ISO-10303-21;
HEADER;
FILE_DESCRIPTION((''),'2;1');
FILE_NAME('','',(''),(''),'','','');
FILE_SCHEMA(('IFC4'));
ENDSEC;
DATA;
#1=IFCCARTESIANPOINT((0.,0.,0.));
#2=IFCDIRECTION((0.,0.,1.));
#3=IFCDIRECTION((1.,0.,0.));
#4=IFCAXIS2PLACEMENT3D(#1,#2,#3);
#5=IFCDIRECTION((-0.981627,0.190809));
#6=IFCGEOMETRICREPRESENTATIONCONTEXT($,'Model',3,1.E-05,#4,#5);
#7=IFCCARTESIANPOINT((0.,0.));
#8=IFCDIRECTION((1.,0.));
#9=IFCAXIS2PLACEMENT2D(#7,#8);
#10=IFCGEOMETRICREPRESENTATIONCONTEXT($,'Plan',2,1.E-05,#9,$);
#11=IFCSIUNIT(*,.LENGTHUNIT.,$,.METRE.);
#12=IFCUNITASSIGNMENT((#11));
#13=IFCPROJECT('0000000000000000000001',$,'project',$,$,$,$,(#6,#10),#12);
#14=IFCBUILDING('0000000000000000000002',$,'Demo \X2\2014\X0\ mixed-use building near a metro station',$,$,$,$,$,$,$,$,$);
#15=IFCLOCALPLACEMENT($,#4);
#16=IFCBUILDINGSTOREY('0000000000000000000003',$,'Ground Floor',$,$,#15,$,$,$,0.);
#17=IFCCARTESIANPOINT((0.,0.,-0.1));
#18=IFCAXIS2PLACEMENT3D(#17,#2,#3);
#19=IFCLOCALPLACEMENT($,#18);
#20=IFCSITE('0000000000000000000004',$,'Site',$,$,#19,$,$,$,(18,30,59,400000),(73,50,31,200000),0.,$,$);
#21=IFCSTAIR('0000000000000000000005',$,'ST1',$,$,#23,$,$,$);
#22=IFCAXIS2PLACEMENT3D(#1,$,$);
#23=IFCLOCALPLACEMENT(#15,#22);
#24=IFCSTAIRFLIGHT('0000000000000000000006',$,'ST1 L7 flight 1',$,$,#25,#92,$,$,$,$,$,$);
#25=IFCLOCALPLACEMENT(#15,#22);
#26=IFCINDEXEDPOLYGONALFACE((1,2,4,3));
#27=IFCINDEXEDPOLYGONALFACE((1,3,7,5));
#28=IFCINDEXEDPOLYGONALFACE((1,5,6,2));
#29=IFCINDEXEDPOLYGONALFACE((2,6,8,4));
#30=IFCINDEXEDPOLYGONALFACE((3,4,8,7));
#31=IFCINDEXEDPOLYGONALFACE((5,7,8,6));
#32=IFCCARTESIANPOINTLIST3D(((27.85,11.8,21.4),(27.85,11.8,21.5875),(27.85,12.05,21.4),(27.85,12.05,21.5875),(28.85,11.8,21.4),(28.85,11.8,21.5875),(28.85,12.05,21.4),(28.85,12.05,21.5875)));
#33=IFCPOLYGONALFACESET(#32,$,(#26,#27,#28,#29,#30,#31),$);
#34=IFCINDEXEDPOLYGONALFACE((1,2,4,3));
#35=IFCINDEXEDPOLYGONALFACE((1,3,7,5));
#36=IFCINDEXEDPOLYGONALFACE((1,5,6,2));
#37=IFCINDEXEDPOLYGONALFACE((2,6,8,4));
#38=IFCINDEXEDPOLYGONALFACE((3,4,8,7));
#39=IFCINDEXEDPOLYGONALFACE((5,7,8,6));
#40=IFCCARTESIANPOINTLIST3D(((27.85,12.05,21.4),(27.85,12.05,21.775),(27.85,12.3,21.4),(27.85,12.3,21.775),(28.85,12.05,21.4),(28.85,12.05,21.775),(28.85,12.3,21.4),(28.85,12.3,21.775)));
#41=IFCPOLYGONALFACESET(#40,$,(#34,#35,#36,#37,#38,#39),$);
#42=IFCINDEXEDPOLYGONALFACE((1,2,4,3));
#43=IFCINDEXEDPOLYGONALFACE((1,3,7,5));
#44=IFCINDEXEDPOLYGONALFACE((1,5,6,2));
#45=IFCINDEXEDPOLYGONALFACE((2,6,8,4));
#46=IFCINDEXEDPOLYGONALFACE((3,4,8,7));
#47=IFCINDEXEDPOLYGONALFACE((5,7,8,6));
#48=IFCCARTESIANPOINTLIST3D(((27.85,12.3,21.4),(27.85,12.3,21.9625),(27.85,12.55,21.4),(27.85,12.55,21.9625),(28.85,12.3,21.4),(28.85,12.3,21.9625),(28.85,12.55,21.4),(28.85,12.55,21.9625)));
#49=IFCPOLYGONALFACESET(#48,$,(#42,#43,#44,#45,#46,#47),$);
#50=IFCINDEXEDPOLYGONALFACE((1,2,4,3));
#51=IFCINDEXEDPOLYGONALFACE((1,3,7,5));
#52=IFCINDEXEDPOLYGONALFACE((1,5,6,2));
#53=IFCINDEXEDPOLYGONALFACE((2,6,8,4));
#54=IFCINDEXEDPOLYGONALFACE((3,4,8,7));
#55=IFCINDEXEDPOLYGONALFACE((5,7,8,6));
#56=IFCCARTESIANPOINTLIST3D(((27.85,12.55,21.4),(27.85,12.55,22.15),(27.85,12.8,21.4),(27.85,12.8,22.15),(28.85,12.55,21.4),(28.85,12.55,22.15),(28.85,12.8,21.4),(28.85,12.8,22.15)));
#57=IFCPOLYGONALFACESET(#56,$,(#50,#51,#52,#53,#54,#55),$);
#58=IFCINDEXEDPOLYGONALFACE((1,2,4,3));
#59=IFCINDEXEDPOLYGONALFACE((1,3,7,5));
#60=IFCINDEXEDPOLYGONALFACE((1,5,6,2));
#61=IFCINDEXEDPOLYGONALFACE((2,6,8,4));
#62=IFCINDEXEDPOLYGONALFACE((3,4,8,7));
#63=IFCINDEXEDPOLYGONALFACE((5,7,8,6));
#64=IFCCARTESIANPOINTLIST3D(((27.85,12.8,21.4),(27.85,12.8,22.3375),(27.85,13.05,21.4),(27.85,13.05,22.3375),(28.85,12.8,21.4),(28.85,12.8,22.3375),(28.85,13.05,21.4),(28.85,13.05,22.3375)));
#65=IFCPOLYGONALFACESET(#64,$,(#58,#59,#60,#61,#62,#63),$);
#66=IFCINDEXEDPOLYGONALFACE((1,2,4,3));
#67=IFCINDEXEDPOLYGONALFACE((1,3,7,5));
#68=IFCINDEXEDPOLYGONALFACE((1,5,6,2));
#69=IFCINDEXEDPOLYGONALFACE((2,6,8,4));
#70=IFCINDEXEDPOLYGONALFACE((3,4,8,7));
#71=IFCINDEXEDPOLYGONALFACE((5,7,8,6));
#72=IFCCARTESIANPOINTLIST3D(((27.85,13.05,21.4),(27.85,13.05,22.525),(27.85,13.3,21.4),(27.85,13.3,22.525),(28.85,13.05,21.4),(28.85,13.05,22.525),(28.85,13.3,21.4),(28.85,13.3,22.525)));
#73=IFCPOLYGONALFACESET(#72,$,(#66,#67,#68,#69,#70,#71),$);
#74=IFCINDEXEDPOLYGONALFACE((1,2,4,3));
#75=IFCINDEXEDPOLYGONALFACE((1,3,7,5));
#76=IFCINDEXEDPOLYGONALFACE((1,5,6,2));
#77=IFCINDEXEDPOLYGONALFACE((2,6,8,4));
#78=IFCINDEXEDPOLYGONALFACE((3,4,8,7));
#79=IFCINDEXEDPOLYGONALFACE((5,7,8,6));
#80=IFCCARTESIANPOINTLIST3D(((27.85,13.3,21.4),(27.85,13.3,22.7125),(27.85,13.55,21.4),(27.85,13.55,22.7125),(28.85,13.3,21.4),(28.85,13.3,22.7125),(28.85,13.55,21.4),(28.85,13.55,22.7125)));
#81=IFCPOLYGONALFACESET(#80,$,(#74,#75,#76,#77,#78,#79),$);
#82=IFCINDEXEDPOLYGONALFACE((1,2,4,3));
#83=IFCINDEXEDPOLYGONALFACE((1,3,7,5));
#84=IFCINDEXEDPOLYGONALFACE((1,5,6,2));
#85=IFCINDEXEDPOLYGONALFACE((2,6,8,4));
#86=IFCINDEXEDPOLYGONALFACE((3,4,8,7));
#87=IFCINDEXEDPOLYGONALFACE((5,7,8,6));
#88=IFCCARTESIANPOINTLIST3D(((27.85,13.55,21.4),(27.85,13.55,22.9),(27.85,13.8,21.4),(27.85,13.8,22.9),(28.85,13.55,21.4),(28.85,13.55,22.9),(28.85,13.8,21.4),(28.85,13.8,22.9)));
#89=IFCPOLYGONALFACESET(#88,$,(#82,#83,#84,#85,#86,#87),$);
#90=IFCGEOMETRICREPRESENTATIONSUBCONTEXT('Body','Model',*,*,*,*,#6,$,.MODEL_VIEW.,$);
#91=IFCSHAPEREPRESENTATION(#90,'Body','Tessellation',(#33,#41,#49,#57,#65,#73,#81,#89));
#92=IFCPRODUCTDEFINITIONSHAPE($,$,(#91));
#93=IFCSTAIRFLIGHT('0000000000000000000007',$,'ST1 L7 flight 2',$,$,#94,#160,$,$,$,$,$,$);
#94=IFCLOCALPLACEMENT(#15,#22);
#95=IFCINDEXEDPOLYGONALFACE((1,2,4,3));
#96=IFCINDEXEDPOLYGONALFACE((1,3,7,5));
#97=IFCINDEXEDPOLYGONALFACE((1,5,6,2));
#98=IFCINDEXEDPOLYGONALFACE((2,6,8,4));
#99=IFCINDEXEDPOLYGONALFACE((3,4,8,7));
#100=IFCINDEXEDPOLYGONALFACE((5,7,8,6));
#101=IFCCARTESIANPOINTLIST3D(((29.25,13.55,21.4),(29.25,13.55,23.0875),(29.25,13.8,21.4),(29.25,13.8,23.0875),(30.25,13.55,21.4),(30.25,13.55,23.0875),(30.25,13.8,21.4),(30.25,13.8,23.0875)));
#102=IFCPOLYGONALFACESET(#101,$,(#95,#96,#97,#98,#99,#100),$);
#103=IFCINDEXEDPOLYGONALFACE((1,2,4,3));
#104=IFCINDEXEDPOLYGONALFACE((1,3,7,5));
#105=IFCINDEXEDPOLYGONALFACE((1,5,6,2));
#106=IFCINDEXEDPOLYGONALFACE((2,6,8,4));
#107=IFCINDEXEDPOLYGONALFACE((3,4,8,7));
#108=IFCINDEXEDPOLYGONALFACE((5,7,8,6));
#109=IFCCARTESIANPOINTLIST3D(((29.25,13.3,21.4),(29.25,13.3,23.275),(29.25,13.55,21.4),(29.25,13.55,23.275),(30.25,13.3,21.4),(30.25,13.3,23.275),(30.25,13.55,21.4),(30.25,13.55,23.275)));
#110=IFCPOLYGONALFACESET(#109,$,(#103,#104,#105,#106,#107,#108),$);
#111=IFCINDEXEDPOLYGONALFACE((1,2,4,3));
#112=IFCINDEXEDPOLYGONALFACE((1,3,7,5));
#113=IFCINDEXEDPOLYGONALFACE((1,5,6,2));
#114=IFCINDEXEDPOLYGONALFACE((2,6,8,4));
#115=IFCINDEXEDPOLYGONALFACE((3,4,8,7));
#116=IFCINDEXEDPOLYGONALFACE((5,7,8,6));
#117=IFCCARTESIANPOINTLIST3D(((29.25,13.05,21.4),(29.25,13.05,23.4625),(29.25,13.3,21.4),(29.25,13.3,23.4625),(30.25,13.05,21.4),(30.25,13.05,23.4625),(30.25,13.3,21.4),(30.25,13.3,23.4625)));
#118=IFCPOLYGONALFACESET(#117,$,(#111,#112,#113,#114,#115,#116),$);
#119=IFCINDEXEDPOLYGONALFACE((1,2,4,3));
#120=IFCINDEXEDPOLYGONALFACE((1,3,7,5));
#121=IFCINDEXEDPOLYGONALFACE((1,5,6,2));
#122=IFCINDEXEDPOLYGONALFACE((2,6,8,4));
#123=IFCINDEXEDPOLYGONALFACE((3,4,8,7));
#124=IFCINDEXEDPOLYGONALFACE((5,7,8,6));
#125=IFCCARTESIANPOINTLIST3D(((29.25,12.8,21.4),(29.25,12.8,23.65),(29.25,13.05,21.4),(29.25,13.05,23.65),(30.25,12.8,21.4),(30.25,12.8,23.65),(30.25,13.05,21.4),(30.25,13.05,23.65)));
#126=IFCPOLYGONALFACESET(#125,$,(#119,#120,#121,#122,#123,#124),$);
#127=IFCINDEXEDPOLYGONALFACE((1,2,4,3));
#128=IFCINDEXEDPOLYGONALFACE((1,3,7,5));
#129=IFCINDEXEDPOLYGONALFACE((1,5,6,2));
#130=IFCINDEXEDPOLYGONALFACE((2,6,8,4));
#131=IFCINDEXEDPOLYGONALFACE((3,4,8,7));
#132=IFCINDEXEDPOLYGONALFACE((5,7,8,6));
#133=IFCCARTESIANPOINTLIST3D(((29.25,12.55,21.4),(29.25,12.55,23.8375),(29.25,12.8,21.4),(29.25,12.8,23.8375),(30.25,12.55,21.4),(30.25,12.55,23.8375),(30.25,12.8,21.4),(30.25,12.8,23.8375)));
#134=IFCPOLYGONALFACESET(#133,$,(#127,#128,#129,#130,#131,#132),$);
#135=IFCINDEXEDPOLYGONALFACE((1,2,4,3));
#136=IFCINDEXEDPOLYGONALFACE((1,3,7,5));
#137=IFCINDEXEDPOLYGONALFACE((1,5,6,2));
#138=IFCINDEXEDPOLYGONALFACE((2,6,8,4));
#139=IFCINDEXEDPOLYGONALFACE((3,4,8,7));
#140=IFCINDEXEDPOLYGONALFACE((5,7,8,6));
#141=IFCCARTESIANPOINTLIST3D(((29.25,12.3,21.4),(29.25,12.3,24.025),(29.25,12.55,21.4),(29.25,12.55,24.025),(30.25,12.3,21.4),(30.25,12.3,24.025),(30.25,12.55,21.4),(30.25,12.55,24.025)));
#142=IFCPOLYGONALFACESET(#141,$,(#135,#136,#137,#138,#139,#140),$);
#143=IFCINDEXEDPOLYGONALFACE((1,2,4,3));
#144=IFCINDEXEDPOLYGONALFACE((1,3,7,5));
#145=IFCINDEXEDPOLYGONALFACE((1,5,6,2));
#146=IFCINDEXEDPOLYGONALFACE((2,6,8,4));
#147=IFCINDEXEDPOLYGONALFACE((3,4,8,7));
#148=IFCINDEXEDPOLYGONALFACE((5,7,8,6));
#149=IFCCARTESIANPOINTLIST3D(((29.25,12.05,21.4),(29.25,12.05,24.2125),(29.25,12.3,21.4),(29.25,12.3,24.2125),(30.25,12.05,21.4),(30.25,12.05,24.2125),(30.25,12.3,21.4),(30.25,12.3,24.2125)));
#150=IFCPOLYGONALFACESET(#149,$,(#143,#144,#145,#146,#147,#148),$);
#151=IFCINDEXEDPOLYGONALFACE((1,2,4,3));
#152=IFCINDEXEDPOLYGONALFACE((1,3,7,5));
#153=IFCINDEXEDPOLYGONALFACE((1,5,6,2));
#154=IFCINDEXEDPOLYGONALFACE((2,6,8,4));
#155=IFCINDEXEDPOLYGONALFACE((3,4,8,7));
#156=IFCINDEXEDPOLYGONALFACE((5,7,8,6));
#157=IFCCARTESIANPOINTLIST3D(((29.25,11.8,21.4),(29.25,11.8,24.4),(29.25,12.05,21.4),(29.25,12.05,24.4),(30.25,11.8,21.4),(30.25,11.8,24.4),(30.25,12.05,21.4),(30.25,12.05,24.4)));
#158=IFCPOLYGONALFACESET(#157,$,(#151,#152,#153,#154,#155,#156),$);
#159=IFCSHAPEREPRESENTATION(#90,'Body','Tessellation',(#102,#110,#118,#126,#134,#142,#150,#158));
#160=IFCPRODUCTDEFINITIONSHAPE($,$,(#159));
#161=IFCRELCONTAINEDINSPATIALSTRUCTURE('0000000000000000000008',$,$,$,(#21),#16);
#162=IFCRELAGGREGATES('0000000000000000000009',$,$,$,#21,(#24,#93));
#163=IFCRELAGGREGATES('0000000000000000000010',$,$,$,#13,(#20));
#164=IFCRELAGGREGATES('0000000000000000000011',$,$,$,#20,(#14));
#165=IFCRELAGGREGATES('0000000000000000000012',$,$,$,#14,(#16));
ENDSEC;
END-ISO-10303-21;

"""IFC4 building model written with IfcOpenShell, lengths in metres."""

from ifc_helpers import new_model, si_unit, direction, frame, origin_with_axes, origin_2d_with_axis, place, context, subcontext, project, spatial, line, indexed_curve, outline, extrude, element, aggregate, save


model = new_model("IFC4")

# Units and contexts
model_context = context("Model", 3, precision=1e-05, world=origin_with_axes(), true_north=direction((-0.981627, 0.190809)))
plan_context = context("Plan", 2, precision=1e-05, world=origin_2d_with_axis())
body_context = subcontext(model_context, "Body", "Model", "MODEL_VIEW")
ifc_project = project(units=[si_unit("LENGTHUNIT", "METRE")], contexts=[model_context, plan_context])

# Site, building, storey
site_placement = place(None, frame((0.0, 0.0, -0.1), z_axis=(0.0, 0.0, 1.0), x_axis=(1.0, 0.0, 0.0)))
site = spatial("IfcSite", under=ifc_project, at=site_placement, Name="Site", RefLatitude=(18, 30, 59, 400000), RefLongitude=(73, 50, 31, 200000), RefElevation=0.0)
building = spatial("IfcBuilding", under=site, Name="Demo — mixed-use building near a metro station")
storey_placement = place(None, origin_with_axes())
storey = spatial("IfcBuildingStorey", under=building, at=storey_placement, Name="Ground Floor", Elevation=0.0)

# Stair, stair flights
stair = element("IfcStair", 1, inside=storey, Name="ST1")
stair_flight_1_placement = place(None, origin_with_axes())
stair_flight_1 = element("IfcStairFlight", 2, at=stair_flight_1_placement, Name="ST1 L7 flight 1", context=body_context, shape_type="SweptSolid", body=[
    extrude(outline(indexed_curve([(27.85, 11.8), (28.85, 11.8), (28.85, 12.05), (27.85, 12.05)], segments=[line(1, 2, 3, 4, 1)])), frame((0.0, 0.0, 21.4), z_axis=(0.0, 0.0, 1.0), x_axis=(1.0, 0.0, 0.0)), (0.0, 0.0, 1.0), 0.1875),
    extrude(outline(indexed_curve([(27.85, 12.05), (28.85, 12.05), (28.85, 12.3), (27.85, 12.3)], segments=[line(1, 2, 3, 4, 1)])), frame((0.0, 0.0, 21.4), z_axis=(0.0, 0.0, 1.0), x_axis=(1.0, 0.0, 0.0)), (0.0, 0.0, 1.0), 0.375),
    extrude(outline(indexed_curve([(27.85, 12.3), (28.85, 12.3), (28.85, 12.55), (27.85, 12.55)], segments=[line(1, 2, 3, 4, 1)])), frame((0.0, 0.0, 21.4), z_axis=(0.0, 0.0, 1.0), x_axis=(1.0, 0.0, 0.0)), (0.0, 0.0, 1.0), 0.5625),
    extrude(outline(indexed_curve([(27.85, 12.55), (28.85, 12.55), (28.85, 12.8), (27.85, 12.8)], segments=[line(1, 2, 3, 4, 1)])), frame((0.0, 0.0, 21.4), z_axis=(0.0, 0.0, 1.0), x_axis=(1.0, 0.0, 0.0)), (0.0, 0.0, 1.0), 0.75),
    extrude(outline(indexed_curve([(27.85, 12.8), (28.85, 12.8), (28.85, 13.05), (27.85, 13.05)], segments=[line(1, 2, 3, 4, 1)])), frame((0.0, 0.0, 21.4), z_axis=(0.0, 0.0, 1.0), x_axis=(1.0, 0.0, 0.0)), (0.0, 0.0, 1.0), 0.9375),
    extrude(outline(indexed_curve([(27.85, 13.05), (28.85, 13.05), (28.85, 13.3), (27.85, 13.3)], segments=[line(1, 2, 3, 4, 1)])), frame((0.0, 0.0, 21.4), z_axis=(0.0, 0.0, 1.0), x_axis=(1.0, 0.0, 0.0)), (0.0, 0.0, 1.0), 1.125),
    extrude(outline(indexed_curve([(27.85, 13.3), (28.85, 13.3), (28.85, 13.55), (27.85, 13.55)], segments=[line(1, 2, 3, 4, 1)])), frame((0.0, 0.0, 21.4), z_axis=(0.0, 0.0, 1.0), x_axis=(1.0, 0.0, 0.0)), (0.0, 0.0, 1.0), 1.3125),
    extrude(outline(indexed_curve([(27.85, 13.55), (28.85, 13.55), (28.85, 13.8), (27.85, 13.8)], segments=[line(1, 2, 3, 4, 1)])), frame((0.0, 0.0, 21.4), z_axis=(0.0, 0.0, 1.0), x_axis=(1.0, 0.0, 0.0)), (0.0, 0.0, 1.0), 1.5),
])
stair_flight_2_placement = place(None, origin_with_axes())
stair_flight_2 = element("IfcStairFlight", 3, at=stair_flight_2_placement, Name="ST1 L7 flight 2", context=body_context, shape_type="SweptSolid", body=[
    extrude(outline(indexed_curve([(29.25, 13.55), (30.25, 13.55), (30.25, 13.8), (29.25, 13.8)], segments=[line(1, 2, 3, 4, 1)])), frame((0.0, 0.0, 21.4), z_axis=(0.0, 0.0, 1.0), x_axis=(1.0, 0.0, 0.0)), (0.0, 0.0, 1.0), 1.6875),
    extrude(outline(indexed_curve([(29.25, 13.3), (30.25, 13.3), (30.25, 13.55), (29.25, 13.55)], segments=[line(1, 2, 3, 4, 1)])), frame((0.0, 0.0, 21.4), z_axis=(0.0, 0.0, 1.0), x_axis=(1.0, 0.0, 0.0)), (0.0, 0.0, 1.0), 1.875),
    extrude(outline(indexed_curve([(29.25, 13.05), (30.25, 13.05), (30.25, 13.3), (29.25, 13.3)], segments=[line(1, 2, 3, 4, 1)])), frame((0.0, 0.0, 21.4), z_axis=(0.0, 0.0, 1.0), x_axis=(1.0, 0.0, 0.0)), (0.0, 0.0, 1.0), 2.0625),
    extrude(outline(indexed_curve([(29.25, 12.8), (30.25, 12.8), (30.25, 13.05), (29.25, 13.05)], segments=[line(1, 2, 3, 4, 1)])), frame((0.0, 0.0, 21.4), z_axis=(0.0, 0.0, 1.0), x_axis=(1.0, 0.0, 0.0)), (0.0, 0.0, 1.0), 2.25),
    extrude(outline(indexed_curve([(29.25, 12.55), (30.25, 12.55), (30.25, 12.8), (29.25, 12.8)], segments=[line(1, 2, 3, 4, 1)])), frame((0.0, 0.0, 21.4), z_axis=(0.0, 0.0, 1.0), x_axis=(1.0, 0.0, 0.0)), (0.0, 0.0, 1.0), 2.4375),
    extrude(outline(indexed_curve([(29.25, 12.3), (30.25, 12.3), (30.25, 12.55), (29.25, 12.55)], segments=[line(1, 2, 3, 4, 1)])), frame((0.0, 0.0, 21.4), z_axis=(0.0, 0.0, 1.0), x_axis=(1.0, 0.0, 0.0)), (0.0, 0.0, 1.0), 2.625),
    extrude(outline(indexed_curve([(29.25, 12.05), (30.25, 12.05), (30.25, 12.3), (29.25, 12.3)], segments=[line(1, 2, 3, 4, 1)])), frame((0.0, 0.0, 21.4), z_axis=(0.0, 0.0, 1.0), x_axis=(1.0, 0.0, 0.0)), (0.0, 0.0, 1.0), 2.8125),
    extrude(outline(indexed_curve([(29.25, 11.8), (30.25, 11.8), (30.25, 12.05), (29.25, 12.05)], segments=[line(1, 2, 3, 4, 1)])), frame((0.0, 0.0, 21.4), z_axis=(0.0, 0.0, 1.0), x_axis=(1.0, 0.0, 0.0)), (0.0, 0.0, 1.0), 3.0),
])
aggregate(stair, [stair_flight_1, stair_flight_2])

save(model, "model.ifc")
